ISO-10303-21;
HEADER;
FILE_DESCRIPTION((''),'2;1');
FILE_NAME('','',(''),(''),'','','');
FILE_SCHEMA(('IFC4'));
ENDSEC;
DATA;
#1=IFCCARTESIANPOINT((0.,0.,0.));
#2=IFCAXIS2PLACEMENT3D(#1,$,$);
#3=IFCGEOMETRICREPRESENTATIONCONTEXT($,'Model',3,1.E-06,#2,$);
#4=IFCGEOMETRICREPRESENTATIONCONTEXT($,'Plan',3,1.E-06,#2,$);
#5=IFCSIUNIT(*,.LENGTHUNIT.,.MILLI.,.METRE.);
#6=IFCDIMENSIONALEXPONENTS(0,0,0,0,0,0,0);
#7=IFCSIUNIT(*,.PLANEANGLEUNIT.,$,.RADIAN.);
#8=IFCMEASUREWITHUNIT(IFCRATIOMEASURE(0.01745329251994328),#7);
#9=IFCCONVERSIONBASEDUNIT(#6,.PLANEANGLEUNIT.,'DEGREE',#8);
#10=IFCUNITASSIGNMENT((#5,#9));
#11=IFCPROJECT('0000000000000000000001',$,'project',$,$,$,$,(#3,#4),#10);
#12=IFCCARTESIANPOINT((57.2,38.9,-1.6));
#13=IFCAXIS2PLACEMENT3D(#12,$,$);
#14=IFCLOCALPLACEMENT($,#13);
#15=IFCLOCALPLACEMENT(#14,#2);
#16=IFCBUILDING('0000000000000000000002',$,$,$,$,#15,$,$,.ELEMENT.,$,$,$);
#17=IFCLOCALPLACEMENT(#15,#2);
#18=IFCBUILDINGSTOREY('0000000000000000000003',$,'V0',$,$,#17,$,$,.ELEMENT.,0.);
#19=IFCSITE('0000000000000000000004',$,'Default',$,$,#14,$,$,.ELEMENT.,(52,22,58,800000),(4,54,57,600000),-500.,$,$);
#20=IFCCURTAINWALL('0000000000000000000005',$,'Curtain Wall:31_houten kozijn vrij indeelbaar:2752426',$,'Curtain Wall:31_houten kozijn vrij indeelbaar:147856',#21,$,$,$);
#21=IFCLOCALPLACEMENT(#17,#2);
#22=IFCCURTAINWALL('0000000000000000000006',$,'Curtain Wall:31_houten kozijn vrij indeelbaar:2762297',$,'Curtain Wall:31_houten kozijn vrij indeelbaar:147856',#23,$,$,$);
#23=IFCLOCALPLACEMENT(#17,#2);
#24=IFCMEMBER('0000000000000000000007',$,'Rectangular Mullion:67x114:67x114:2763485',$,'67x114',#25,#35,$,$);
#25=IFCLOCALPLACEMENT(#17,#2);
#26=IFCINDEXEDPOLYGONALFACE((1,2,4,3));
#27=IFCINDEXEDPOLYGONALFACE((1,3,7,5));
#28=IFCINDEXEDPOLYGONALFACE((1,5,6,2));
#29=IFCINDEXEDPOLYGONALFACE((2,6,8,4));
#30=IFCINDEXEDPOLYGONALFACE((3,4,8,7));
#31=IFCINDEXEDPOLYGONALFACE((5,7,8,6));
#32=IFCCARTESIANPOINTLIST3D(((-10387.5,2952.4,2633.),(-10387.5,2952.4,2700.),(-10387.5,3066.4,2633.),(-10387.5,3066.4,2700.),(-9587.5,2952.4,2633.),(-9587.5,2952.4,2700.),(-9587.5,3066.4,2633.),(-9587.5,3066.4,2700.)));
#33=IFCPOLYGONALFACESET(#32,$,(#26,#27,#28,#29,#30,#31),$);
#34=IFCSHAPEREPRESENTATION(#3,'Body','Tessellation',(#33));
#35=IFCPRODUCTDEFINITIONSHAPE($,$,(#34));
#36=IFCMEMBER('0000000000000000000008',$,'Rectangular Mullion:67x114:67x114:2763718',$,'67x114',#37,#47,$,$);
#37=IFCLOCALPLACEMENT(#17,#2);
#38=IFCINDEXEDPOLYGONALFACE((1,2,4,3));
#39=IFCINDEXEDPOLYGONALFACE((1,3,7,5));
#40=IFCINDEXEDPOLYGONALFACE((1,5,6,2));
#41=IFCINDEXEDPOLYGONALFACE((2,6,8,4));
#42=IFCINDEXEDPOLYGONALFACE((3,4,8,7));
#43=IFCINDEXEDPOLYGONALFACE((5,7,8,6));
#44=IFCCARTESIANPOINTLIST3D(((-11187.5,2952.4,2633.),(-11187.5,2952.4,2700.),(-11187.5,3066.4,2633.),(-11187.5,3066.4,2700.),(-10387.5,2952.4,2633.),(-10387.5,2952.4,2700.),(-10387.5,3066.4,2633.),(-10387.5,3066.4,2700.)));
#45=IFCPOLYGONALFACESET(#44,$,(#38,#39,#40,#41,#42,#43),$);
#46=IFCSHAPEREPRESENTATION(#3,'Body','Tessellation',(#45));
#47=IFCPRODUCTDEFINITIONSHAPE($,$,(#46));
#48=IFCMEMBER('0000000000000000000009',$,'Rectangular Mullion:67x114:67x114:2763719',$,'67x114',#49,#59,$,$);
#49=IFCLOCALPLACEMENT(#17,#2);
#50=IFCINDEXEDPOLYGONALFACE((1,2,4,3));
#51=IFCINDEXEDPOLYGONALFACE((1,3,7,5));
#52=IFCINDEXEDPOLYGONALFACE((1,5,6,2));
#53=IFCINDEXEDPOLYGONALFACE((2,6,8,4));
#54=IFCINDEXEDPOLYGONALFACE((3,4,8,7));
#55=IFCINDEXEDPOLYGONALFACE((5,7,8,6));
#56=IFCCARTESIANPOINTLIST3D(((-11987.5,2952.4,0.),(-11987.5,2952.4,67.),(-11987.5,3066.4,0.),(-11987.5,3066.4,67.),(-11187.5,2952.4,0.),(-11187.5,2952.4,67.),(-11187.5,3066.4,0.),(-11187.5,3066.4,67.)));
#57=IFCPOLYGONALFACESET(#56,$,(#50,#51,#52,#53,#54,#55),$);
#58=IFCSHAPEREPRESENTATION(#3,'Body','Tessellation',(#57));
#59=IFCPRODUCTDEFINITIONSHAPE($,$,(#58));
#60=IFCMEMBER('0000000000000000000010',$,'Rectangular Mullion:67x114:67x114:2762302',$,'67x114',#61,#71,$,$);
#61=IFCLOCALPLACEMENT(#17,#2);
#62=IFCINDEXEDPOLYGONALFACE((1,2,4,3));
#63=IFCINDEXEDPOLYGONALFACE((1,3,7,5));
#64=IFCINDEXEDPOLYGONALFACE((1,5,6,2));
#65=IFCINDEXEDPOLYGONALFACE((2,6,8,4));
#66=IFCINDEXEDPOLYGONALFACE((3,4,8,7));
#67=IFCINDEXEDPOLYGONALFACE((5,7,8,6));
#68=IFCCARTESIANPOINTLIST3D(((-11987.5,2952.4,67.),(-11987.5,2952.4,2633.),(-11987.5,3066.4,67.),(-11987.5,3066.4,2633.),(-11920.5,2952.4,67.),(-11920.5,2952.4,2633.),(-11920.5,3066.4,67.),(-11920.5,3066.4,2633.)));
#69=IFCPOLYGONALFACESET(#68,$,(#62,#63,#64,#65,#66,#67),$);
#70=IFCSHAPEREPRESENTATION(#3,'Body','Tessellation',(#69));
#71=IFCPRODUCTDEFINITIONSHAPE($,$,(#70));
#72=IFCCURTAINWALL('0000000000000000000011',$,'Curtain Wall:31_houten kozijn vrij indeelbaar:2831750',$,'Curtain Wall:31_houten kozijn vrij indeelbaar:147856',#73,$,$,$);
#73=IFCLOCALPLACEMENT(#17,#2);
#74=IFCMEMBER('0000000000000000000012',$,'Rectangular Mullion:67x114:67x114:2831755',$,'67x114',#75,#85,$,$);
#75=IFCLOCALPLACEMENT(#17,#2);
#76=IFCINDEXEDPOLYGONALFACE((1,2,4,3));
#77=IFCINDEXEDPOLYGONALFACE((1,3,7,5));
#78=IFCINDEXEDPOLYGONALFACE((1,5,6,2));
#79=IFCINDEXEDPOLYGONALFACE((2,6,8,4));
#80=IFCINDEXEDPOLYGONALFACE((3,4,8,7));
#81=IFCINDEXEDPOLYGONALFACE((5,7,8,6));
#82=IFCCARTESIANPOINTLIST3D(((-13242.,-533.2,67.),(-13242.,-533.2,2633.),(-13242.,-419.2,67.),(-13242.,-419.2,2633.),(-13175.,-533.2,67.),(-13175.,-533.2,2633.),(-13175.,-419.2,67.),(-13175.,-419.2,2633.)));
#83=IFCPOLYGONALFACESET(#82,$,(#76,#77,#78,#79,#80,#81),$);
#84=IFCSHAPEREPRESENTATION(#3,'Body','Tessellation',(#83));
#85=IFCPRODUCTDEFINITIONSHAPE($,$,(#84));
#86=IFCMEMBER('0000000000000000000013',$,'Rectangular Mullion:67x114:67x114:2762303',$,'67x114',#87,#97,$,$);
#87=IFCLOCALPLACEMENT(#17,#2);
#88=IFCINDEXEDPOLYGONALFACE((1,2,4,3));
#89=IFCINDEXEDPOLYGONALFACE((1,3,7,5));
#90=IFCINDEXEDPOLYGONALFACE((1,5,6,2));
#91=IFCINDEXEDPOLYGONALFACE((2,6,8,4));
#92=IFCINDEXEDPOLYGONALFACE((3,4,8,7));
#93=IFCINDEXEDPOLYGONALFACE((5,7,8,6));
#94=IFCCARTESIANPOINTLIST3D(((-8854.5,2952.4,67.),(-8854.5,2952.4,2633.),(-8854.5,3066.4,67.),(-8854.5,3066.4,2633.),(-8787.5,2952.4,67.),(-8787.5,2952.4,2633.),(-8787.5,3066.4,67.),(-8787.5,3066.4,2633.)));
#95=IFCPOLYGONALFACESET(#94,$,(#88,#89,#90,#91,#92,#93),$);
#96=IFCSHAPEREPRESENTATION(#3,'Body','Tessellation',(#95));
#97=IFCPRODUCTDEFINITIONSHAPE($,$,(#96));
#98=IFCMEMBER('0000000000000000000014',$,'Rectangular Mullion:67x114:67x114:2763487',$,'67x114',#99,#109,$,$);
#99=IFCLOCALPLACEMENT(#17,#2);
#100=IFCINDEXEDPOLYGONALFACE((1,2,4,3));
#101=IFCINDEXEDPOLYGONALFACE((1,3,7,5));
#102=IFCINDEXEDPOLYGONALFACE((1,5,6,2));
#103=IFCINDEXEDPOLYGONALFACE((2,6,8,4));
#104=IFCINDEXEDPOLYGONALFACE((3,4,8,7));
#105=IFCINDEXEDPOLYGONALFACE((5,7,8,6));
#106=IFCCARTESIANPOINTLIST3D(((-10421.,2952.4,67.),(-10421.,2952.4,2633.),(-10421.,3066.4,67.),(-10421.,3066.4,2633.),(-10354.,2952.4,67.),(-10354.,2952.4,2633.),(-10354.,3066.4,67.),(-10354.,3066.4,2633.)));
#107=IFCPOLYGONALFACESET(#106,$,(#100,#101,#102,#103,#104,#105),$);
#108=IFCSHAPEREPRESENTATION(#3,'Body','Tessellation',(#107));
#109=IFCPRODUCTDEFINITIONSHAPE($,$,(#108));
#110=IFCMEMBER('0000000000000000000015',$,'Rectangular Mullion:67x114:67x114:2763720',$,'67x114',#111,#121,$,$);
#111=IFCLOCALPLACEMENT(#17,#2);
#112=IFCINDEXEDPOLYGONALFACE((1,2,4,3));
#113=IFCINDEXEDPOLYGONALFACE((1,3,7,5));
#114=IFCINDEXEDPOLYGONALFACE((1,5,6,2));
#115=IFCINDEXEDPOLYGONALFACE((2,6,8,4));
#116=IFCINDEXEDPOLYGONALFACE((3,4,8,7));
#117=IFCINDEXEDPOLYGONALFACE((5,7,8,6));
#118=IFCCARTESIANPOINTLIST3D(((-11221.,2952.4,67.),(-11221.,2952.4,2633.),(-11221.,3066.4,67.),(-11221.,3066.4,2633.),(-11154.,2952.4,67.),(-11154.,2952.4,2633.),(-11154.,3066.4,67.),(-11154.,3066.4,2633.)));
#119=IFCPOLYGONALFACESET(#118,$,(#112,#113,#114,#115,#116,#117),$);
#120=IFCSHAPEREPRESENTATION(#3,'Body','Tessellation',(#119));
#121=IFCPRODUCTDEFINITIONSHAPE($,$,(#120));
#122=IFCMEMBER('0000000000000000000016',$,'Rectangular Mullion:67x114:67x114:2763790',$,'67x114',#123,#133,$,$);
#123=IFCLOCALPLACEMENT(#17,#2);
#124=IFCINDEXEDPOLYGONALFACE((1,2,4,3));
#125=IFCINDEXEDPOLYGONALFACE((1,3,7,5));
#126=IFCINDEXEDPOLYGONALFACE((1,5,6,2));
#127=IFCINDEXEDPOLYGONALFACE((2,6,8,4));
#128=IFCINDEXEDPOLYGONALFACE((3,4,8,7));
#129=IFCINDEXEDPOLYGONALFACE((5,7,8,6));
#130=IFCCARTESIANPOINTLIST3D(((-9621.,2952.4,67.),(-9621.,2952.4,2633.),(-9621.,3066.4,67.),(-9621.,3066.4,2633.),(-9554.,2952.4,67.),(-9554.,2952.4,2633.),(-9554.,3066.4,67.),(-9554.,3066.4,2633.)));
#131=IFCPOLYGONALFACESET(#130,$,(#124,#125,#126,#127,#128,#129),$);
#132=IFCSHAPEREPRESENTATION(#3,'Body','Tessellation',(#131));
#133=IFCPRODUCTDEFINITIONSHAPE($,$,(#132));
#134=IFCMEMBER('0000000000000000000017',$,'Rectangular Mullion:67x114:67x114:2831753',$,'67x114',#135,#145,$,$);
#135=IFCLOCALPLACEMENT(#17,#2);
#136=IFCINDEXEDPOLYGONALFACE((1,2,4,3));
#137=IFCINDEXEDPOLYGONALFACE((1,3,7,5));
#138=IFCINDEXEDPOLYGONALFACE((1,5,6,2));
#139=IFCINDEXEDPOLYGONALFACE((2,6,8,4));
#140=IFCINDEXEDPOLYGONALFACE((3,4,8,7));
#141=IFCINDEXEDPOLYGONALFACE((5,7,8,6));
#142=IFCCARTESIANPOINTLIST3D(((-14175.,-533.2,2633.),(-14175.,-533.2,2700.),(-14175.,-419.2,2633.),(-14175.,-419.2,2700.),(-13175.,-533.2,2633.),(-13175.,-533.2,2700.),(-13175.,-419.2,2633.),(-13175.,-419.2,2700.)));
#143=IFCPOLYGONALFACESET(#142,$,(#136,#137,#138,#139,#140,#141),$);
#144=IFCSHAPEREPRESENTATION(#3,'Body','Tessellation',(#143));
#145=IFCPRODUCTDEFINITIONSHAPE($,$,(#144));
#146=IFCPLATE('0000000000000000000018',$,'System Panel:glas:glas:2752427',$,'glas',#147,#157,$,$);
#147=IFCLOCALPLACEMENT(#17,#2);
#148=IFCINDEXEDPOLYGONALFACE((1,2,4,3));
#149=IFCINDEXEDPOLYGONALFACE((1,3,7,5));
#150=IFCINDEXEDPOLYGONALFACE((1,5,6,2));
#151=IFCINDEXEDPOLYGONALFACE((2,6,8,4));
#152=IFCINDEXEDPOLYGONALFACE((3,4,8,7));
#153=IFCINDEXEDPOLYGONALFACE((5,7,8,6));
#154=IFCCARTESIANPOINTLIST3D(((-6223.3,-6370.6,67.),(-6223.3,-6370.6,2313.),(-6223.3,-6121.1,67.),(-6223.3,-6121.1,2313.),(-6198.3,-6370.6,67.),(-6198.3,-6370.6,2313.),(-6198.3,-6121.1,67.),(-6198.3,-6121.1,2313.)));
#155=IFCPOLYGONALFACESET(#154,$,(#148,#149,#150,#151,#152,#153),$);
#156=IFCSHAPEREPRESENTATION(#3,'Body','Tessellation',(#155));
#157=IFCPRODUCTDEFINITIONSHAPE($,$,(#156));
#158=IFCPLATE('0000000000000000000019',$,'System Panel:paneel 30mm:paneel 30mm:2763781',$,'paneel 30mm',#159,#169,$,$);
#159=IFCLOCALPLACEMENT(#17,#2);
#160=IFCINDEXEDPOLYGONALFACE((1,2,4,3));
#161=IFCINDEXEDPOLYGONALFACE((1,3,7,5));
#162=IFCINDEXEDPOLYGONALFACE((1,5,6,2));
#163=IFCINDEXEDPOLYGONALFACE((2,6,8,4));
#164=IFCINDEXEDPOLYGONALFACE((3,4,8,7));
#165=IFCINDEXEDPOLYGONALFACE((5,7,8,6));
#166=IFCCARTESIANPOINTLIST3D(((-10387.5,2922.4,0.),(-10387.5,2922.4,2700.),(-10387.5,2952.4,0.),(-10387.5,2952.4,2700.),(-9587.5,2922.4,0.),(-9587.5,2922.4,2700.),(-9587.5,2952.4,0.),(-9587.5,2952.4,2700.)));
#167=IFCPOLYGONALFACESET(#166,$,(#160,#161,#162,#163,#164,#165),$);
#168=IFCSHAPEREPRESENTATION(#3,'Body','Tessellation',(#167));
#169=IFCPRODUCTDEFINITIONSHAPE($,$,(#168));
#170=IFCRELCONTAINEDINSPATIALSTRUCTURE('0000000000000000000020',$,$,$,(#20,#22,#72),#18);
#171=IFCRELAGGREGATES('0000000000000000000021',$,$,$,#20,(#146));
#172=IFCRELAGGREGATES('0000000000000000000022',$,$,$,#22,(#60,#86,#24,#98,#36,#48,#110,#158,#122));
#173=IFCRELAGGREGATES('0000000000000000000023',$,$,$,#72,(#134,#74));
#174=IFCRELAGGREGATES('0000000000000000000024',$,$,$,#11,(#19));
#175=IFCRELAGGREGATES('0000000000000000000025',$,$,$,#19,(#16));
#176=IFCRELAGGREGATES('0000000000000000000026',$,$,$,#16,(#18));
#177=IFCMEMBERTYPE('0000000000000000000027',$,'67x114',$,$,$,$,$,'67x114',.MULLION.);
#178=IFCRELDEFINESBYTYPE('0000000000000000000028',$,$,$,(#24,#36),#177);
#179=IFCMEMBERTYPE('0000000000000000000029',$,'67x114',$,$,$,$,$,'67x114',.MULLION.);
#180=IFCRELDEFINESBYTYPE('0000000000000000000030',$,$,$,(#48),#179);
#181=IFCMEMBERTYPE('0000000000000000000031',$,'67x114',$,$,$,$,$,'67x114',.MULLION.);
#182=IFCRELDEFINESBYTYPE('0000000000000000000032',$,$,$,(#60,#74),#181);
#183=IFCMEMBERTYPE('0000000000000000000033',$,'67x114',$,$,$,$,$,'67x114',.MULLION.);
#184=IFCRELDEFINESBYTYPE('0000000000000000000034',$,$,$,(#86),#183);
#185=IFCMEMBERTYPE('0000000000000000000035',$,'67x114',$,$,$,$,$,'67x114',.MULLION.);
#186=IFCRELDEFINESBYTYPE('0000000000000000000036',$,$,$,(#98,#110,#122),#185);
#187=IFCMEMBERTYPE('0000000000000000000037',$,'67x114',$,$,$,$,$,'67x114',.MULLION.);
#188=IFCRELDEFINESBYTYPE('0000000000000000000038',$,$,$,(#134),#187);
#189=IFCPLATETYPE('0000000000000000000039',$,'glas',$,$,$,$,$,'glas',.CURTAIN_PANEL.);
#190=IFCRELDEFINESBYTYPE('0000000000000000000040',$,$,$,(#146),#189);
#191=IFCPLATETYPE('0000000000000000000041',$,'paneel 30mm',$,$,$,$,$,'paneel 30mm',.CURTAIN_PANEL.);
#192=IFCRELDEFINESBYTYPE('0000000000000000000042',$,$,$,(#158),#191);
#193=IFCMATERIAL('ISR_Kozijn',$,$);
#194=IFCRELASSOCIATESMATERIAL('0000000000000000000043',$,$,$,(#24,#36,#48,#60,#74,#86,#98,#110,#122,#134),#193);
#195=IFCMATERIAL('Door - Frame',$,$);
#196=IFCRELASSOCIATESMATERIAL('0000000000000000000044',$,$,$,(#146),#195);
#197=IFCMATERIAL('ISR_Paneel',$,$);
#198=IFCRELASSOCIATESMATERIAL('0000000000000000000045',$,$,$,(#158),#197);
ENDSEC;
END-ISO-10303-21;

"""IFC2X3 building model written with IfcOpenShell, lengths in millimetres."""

from ifc_helpers import new_model, entity, si_unit, converted_unit, frame, origin, origin_2d_with_axis, place, context, project, spatial, rectangle, extrude, source, transform, mapped, material, type_object, type_shapes, element, aggregate, save


model = new_model("IFC2X3")

# Units and contexts
model_context = context("Model", 3, precision=1e-06, world=origin())
plan_context = context("Plan", 3, precision=1e-06, world=origin())
ifc_project = project(units=[si_unit("LENGTHUNIT", "METRE", prefix="MILLI"), converted_unit("PLANEANGLEUNIT", "DEGREE", entity("IfcRatioMeasure", 0.01745329251994328), si_unit("PLANEANGLEUNIT", "RADIAN"), dimensions=[0, 0, 0, 0, 0, 0, 0])], contexts=[model_context, plan_context])

# Site, building, storey
site_placement = place(None, frame((57.2, 38.9, -1.6)))
site = spatial("IfcSite", under=ifc_project, at=site_placement, Name="Default", CompositionType="ELEMENT", RefLatitude=(52, 22, 58, 800000), RefLongitude=(4, 54, 57, 600000), RefElevation=-500.0)
building_placement = place(site_placement, origin())
building = spatial("IfcBuilding", under=site, at=building_placement, CompositionType="ELEMENT")
storey_placement = place(building_placement, origin())
storey = spatial("IfcBuildingStorey", under=building, at=storey_placement, Name="V0", CompositionType="ELEMENT", Elevation=0.0)

# Curtain walls, members
curtain_wall_1_placement = place(storey_placement, origin())
curtain_wall_1 = element("IfcCurtainWall", 1, at=curtain_wall_1_placement, inside=storey, Name="Curtain Wall:31_houten kozijn vrij indeelbaar:2752426", ObjectType="Curtain Wall:31_houten kozijn vrij indeelbaar:147856")
ifc_material_1 = material(Name="ISR_Kozijn")
placement_1 = place(building_placement, origin())
curtain_wall_2_placement = place(storey_placement, origin())
curtain_wall_2 = element("IfcCurtainWall", 2, at=curtain_wall_2_placement, inside=storey, Name="Curtain Wall:31_houten kozijn vrij indeelbaar:2762297", ObjectType="Curtain Wall:31_houten kozijn vrij indeelbaar:147856")
placement_2 = place(building_placement, frame((0.0, 0.0, 2425.0)))
member_type_1 = type_object("IfcMemberType", Name="67x114", ElementType="67x114", PredefinedType="MULLION")
shared_shape_1 = source(origin(), model_context, "Body", "SweptSolid", [
    extrude(rectangle(XDim=67.0, YDim=114.0, at=origin_2d_with_axis()), frame((-33.5, 57.0, -800.0), z_axis=(0.0, 0.0, 1.0), x_axis=(-1.0, 0.0, 0.0)), (0.0, 0.0, 1.0), 800.0),
])
type_shapes(member_type_1, [shared_shape_1])
member_1_placement = place(placement_2, frame((-10387.5, 2952.4, 275.0), z_axis=(-1.0, 0.0, 0.0), x_axis=(0.0, 0.0, 1.0)))
member_1 = element("IfcMember", 3, at=member_1_placement, type_object=member_type_1, material=ifc_material_1, Name="Rectangular Mullion:67x114:67x114:2763485", ObjectType="67x114", context=model_context, shape_type="MappedRepresentation", body=[
    mapped(shared_shape_1, transform((0.0, 0.0, 0.0), scale=1.0)),
])
member_2_placement = place(placement_2, frame((-11187.5, 2952.4, 275.0), z_axis=(-1.0, 0.0, 0.0), x_axis=(0.0, 0.0, 1.0)))
member_2 = element("IfcMember", 4, at=member_2_placement, type_object=member_type_1, material=ifc_material_1, Name="Rectangular Mullion:67x114:67x114:2763718", ObjectType="67x114", context=model_context, shape_type="MappedRepresentation", body=[
    mapped(shared_shape_1, transform((0.0, 0.0, 0.0), scale=1.0)),
])
member_type_2 = type_object("IfcMemberType", Name="67x114", ElementType="67x114", PredefinedType="MULLION")
shared_shape_2 = source(origin(), model_context, "Body", "SweptSolid", [
    extrude(rectangle(XDim=67.0, YDim=114.0, at=origin_2d_with_axis()), frame((-33.5, 57.0, -800.0), z_axis=(0.0, 0.0, 1.0), x_axis=(-1.0, 0.0, 0.0)), (0.0, 0.0, 1.0), 800.0),
])
type_shapes(member_type_2, [shared_shape_2])
member_3_placement = place(placement_1, frame((-11187.5, 2952.4, 0.0), z_axis=(1.0, 0.0, 0.0), x_axis=(0.0, 0.0, -1.0)))
member_3 = element("IfcMember", 5, at=member_3_placement, type_object=member_type_2, material=ifc_material_1, Name="Rectangular Mullion:67x114:67x114:2763719", ObjectType="67x114", context=model_context, shape_type="MappedRepresentation", body=[
    mapped(shared_shape_2, transform((0.0, 0.0, 0.0), scale=1.0)),
])
member_type_3 = type_object("IfcMemberType", Name="67x114", ElementType="67x114", PredefinedType="MULLION")
shared_shape_3 = source(origin(), model_context, "Body", "SweptSolid", [
    extrude(rectangle(XDim=67.0, YDim=114.0, at=origin_2d_with_axis()), frame((-33.5, 57.0, -2566.0), z_axis=(0.0, 0.0, 1.0), x_axis=(-1.0, 0.0, 0.0)), (0.0, 0.0, 1.0), 2566.0),
])
type_shapes(member_type_3, [shared_shape_3])
member_4_placement = place(placement_1, frame((-11987.5, 2952.4, 67.0), z_axis=(0.0, 0.0, -1.0), x_axis=(-1.0, 0.0, 0.0)))
member_4 = element("IfcMember", 6, at=member_4_placement, type_object=member_type_3, material=ifc_material_1, Name="Rectangular Mullion:67x114:67x114:2762302", ObjectType="67x114", context=model_context, shape_type="MappedRepresentation", body=[
    mapped(shared_shape_3, transform((0.0, 0.0, 0.0), scale=1.0)),
])

# Curtain wall, member
curtain_wall_3_placement = place(storey_placement, origin())
curtain_wall_3 = element("IfcCurtainWall", 7, at=curtain_wall_3_placement, inside=storey, Name="Curtain Wall:31_houten kozijn vrij indeelbaar:2831750", ObjectType="Curtain Wall:31_houten kozijn vrij indeelbaar:147856")
member_5_placement = place(placement_1, frame((-13175.0, -419.2, 67.0), z_axis=(0.0, 0.0, -1.0), x_axis=(1.0, 0.0, 0.0)))
member_5 = element("IfcMember", 8, at=member_5_placement, type_object=member_type_3, material=ifc_material_1, Name="Rectangular Mullion:67x114:67x114:2831755", ObjectType="67x114", context=model_context, shape_type="MappedRepresentation", body=[
    mapped(shared_shape_3, transform((0.0, 0.0, 0.0), scale=1.0)),
])

# Members
member_type_4 = type_object("IfcMemberType", Name="67x114", ElementType="67x114", PredefinedType="MULLION")
shared_shape_4 = source(origin(), model_context, "Body", "SweptSolid", [
    extrude(rectangle(XDim=67.0, YDim=114.0, at=origin_2d_with_axis()), frame((-33.5, 57.0, -2566.0), z_axis=(0.0, 0.0, 1.0), x_axis=(-1.0, 0.0, 0.0)), (0.0, 0.0, 1.0), 2566.0),
])
type_shapes(member_type_4, [shared_shape_4])
member_6_placement = place(placement_1, frame((-8787.5, 2952.4, 2633.0)))
member_6 = element("IfcMember", 9, at=member_6_placement, type_object=member_type_4, material=ifc_material_1, Name="Rectangular Mullion:67x114:67x114:2762303", ObjectType="67x114", context=model_context, shape_type="MappedRepresentation", body=[
    mapped(shared_shape_4, transform((0.0, 0.0, 0.0), scale=1.0)),
])
member_type_5 = type_object("IfcMemberType", Name="67x114", ElementType="67x114", PredefinedType="MULLION")
shared_shape_5 = source(origin(), model_context, "Body", "SweptSolid", [
    extrude(rectangle(XDim=67.0, YDim=114.0, at=origin_2d_with_axis()), frame((0.0, 57.0, -2566.0), z_axis=(0.0, 0.0, 1.0), x_axis=(-1.0, 0.0, 0.0)), (0.0, 0.0, 1.0), 2566.0),
])
type_shapes(member_type_5, [shared_shape_5])
member_7_placement = place(placement_1, frame((-10387.5, 2952.4, 67.0), z_axis=(0.0, 0.0, -1.0), x_axis=(-1.0, 0.0, 0.0)))
member_7 = element("IfcMember", 10, at=member_7_placement, type_object=member_type_5, material=ifc_material_1, Name="Rectangular Mullion:67x114:67x114:2763487", ObjectType="67x114", context=model_context, shape_type="MappedRepresentation", body=[
    mapped(shared_shape_5, transform((0.0, 0.0, 0.0), scale=1.0)),
])
member_8_placement = place(placement_1, frame((-11187.5, 2952.4, 67.0), z_axis=(0.0, 0.0, -1.0), x_axis=(-1.0, 0.0, 0.0)))
member_8 = element("IfcMember", 11, at=member_8_placement, type_object=member_type_5, material=ifc_material_1, Name="Rectangular Mullion:67x114:67x114:2763720", ObjectType="67x114", context=model_context, shape_type="MappedRepresentation", body=[
    mapped(shared_shape_5, transform((0.0, 0.0, 0.0), scale=1.0)),
])
member_9_placement = place(placement_1, frame((-9587.5, 2952.4, 67.0), z_axis=(0.0, 0.0, -1.0), x_axis=(-1.0, 0.0, 0.0)))
member_9 = element("IfcMember", 12, at=member_9_placement, type_object=member_type_5, material=ifc_material_1, Name="Rectangular Mullion:67x114:67x114:2763790", ObjectType="67x114", context=model_context, shape_type="MappedRepresentation", body=[
    mapped(shared_shape_5, transform((0.0, 0.0, 0.0), scale=1.0)),
])
member_type_6 = type_object("IfcMemberType", Name="67x114", ElementType="67x114", PredefinedType="MULLION")
shared_shape_6 = source(origin(), model_context, "Body", "SweptSolid", [
    extrude(rectangle(XDim=67.0, YDim=114.0, at=origin_2d_with_axis()), frame((-33.5, 57.0, -1000.0), z_axis=(0.0, 0.0, 1.0), x_axis=(-1.0, 0.0, 0.0)), (0.0, 0.0, 1.0), 1000.0),
])
type_shapes(member_type_6, [shared_shape_6])
member_10_placement = place(placement_2, frame((-13175.0, -419.2, 275.0), z_axis=(1.0, 0.0, 0.0), x_axis=(0.0, 0.0, 1.0)))
member_10 = element("IfcMember", 13, at=member_10_placement, type_object=member_type_6, material=ifc_material_1, Name="Rectangular Mullion:67x114:67x114:2831753", ObjectType="67x114", context=model_context, shape_type="MappedRepresentation", body=[
    mapped(shared_shape_6, transform((0.0, 0.0, 0.0), scale=1.0)),
])

# Plate
ifc_material_2 = material(Name="Door - Frame")
plate_type_1 = type_object("IfcPlateType", Name="glas", ElementType="glas", PredefinedType="CURTAIN_PANEL")
shared_shape_7 = source(origin(), model_context, "Body", "SweptSolid", [
    extrude(rectangle(XDim=25.0, YDim=249.5, at=origin_2d_with_axis()), frame((0.0, -35.0, 0.0), z_axis=(0.0, 0.0, 1.0), x_axis=(0.0, 1.0, 0.0)), (0.0, 0.0, 1.0), 2246.0),
])
type_shapes(plate_type_1, [shared_shape_7])
plate_1_placement = place(placement_1, frame((-6245.8, -6245.9, 67.0), z_axis=(0.0, 0.0, 1.0), x_axis=(0.0, 1.0, 0.0)))
plate_1 = element("IfcPlate", 14, at=plate_1_placement, type_object=plate_type_1, material=ifc_material_2, Name="System Panel:glas:glas:2752427", ObjectType="glas", context=model_context, shape_type="MappedRepresentation", body=[
    mapped(shared_shape_7, transform((0.0, 0.0, 0.0), scale=1.0)),
])
aggregate(curtain_wall_1, [plate_1])

# Plate
ifc_material_3 = material(Name="ISR_Paneel")
plate_type_2 = type_object("IfcPlateType", Name="paneel 30mm", ElementType="paneel 30mm", PredefinedType="CURTAIN_PANEL")
shared_shape_8 = source(origin(), model_context, "Body", "SweptSolid", [
    extrude(rectangle(XDim=30.0, YDim=800.0, at=origin_2d_with_axis()), frame((0.0, 15.0, 0.0), z_axis=(0.0, 0.0, 1.0), x_axis=(0.0, 1.0, 0.0)), (0.0, 0.0, 1.0), 2700.0),
])
type_shapes(plate_type_2, [shared_shape_8])
plate_2_placement = place(placement_1, frame((-9987.5, 2952.4, 0.0), z_axis=(0.0, 0.0, 1.0), x_axis=(-1.0, 0.0, 0.0)))
plate_2 = element("IfcPlate", 15, at=plate_2_placement, type_object=plate_type_2, material=ifc_material_3, Name="System Panel:paneel 30mm:paneel 30mm:2763781", ObjectType="paneel 30mm", context=model_context, shape_type="MappedRepresentation", body=[
    mapped(shared_shape_8, transform((0.0, 0.0, 0.0), scale=1.0)),
])
aggregate(curtain_wall_2, [member_4, member_6, member_1, member_7, member_2, member_3, member_8, plate_2, member_9])

aggregate(curtain_wall_3, [member_10, member_5])

save(model, "model.ifc")
